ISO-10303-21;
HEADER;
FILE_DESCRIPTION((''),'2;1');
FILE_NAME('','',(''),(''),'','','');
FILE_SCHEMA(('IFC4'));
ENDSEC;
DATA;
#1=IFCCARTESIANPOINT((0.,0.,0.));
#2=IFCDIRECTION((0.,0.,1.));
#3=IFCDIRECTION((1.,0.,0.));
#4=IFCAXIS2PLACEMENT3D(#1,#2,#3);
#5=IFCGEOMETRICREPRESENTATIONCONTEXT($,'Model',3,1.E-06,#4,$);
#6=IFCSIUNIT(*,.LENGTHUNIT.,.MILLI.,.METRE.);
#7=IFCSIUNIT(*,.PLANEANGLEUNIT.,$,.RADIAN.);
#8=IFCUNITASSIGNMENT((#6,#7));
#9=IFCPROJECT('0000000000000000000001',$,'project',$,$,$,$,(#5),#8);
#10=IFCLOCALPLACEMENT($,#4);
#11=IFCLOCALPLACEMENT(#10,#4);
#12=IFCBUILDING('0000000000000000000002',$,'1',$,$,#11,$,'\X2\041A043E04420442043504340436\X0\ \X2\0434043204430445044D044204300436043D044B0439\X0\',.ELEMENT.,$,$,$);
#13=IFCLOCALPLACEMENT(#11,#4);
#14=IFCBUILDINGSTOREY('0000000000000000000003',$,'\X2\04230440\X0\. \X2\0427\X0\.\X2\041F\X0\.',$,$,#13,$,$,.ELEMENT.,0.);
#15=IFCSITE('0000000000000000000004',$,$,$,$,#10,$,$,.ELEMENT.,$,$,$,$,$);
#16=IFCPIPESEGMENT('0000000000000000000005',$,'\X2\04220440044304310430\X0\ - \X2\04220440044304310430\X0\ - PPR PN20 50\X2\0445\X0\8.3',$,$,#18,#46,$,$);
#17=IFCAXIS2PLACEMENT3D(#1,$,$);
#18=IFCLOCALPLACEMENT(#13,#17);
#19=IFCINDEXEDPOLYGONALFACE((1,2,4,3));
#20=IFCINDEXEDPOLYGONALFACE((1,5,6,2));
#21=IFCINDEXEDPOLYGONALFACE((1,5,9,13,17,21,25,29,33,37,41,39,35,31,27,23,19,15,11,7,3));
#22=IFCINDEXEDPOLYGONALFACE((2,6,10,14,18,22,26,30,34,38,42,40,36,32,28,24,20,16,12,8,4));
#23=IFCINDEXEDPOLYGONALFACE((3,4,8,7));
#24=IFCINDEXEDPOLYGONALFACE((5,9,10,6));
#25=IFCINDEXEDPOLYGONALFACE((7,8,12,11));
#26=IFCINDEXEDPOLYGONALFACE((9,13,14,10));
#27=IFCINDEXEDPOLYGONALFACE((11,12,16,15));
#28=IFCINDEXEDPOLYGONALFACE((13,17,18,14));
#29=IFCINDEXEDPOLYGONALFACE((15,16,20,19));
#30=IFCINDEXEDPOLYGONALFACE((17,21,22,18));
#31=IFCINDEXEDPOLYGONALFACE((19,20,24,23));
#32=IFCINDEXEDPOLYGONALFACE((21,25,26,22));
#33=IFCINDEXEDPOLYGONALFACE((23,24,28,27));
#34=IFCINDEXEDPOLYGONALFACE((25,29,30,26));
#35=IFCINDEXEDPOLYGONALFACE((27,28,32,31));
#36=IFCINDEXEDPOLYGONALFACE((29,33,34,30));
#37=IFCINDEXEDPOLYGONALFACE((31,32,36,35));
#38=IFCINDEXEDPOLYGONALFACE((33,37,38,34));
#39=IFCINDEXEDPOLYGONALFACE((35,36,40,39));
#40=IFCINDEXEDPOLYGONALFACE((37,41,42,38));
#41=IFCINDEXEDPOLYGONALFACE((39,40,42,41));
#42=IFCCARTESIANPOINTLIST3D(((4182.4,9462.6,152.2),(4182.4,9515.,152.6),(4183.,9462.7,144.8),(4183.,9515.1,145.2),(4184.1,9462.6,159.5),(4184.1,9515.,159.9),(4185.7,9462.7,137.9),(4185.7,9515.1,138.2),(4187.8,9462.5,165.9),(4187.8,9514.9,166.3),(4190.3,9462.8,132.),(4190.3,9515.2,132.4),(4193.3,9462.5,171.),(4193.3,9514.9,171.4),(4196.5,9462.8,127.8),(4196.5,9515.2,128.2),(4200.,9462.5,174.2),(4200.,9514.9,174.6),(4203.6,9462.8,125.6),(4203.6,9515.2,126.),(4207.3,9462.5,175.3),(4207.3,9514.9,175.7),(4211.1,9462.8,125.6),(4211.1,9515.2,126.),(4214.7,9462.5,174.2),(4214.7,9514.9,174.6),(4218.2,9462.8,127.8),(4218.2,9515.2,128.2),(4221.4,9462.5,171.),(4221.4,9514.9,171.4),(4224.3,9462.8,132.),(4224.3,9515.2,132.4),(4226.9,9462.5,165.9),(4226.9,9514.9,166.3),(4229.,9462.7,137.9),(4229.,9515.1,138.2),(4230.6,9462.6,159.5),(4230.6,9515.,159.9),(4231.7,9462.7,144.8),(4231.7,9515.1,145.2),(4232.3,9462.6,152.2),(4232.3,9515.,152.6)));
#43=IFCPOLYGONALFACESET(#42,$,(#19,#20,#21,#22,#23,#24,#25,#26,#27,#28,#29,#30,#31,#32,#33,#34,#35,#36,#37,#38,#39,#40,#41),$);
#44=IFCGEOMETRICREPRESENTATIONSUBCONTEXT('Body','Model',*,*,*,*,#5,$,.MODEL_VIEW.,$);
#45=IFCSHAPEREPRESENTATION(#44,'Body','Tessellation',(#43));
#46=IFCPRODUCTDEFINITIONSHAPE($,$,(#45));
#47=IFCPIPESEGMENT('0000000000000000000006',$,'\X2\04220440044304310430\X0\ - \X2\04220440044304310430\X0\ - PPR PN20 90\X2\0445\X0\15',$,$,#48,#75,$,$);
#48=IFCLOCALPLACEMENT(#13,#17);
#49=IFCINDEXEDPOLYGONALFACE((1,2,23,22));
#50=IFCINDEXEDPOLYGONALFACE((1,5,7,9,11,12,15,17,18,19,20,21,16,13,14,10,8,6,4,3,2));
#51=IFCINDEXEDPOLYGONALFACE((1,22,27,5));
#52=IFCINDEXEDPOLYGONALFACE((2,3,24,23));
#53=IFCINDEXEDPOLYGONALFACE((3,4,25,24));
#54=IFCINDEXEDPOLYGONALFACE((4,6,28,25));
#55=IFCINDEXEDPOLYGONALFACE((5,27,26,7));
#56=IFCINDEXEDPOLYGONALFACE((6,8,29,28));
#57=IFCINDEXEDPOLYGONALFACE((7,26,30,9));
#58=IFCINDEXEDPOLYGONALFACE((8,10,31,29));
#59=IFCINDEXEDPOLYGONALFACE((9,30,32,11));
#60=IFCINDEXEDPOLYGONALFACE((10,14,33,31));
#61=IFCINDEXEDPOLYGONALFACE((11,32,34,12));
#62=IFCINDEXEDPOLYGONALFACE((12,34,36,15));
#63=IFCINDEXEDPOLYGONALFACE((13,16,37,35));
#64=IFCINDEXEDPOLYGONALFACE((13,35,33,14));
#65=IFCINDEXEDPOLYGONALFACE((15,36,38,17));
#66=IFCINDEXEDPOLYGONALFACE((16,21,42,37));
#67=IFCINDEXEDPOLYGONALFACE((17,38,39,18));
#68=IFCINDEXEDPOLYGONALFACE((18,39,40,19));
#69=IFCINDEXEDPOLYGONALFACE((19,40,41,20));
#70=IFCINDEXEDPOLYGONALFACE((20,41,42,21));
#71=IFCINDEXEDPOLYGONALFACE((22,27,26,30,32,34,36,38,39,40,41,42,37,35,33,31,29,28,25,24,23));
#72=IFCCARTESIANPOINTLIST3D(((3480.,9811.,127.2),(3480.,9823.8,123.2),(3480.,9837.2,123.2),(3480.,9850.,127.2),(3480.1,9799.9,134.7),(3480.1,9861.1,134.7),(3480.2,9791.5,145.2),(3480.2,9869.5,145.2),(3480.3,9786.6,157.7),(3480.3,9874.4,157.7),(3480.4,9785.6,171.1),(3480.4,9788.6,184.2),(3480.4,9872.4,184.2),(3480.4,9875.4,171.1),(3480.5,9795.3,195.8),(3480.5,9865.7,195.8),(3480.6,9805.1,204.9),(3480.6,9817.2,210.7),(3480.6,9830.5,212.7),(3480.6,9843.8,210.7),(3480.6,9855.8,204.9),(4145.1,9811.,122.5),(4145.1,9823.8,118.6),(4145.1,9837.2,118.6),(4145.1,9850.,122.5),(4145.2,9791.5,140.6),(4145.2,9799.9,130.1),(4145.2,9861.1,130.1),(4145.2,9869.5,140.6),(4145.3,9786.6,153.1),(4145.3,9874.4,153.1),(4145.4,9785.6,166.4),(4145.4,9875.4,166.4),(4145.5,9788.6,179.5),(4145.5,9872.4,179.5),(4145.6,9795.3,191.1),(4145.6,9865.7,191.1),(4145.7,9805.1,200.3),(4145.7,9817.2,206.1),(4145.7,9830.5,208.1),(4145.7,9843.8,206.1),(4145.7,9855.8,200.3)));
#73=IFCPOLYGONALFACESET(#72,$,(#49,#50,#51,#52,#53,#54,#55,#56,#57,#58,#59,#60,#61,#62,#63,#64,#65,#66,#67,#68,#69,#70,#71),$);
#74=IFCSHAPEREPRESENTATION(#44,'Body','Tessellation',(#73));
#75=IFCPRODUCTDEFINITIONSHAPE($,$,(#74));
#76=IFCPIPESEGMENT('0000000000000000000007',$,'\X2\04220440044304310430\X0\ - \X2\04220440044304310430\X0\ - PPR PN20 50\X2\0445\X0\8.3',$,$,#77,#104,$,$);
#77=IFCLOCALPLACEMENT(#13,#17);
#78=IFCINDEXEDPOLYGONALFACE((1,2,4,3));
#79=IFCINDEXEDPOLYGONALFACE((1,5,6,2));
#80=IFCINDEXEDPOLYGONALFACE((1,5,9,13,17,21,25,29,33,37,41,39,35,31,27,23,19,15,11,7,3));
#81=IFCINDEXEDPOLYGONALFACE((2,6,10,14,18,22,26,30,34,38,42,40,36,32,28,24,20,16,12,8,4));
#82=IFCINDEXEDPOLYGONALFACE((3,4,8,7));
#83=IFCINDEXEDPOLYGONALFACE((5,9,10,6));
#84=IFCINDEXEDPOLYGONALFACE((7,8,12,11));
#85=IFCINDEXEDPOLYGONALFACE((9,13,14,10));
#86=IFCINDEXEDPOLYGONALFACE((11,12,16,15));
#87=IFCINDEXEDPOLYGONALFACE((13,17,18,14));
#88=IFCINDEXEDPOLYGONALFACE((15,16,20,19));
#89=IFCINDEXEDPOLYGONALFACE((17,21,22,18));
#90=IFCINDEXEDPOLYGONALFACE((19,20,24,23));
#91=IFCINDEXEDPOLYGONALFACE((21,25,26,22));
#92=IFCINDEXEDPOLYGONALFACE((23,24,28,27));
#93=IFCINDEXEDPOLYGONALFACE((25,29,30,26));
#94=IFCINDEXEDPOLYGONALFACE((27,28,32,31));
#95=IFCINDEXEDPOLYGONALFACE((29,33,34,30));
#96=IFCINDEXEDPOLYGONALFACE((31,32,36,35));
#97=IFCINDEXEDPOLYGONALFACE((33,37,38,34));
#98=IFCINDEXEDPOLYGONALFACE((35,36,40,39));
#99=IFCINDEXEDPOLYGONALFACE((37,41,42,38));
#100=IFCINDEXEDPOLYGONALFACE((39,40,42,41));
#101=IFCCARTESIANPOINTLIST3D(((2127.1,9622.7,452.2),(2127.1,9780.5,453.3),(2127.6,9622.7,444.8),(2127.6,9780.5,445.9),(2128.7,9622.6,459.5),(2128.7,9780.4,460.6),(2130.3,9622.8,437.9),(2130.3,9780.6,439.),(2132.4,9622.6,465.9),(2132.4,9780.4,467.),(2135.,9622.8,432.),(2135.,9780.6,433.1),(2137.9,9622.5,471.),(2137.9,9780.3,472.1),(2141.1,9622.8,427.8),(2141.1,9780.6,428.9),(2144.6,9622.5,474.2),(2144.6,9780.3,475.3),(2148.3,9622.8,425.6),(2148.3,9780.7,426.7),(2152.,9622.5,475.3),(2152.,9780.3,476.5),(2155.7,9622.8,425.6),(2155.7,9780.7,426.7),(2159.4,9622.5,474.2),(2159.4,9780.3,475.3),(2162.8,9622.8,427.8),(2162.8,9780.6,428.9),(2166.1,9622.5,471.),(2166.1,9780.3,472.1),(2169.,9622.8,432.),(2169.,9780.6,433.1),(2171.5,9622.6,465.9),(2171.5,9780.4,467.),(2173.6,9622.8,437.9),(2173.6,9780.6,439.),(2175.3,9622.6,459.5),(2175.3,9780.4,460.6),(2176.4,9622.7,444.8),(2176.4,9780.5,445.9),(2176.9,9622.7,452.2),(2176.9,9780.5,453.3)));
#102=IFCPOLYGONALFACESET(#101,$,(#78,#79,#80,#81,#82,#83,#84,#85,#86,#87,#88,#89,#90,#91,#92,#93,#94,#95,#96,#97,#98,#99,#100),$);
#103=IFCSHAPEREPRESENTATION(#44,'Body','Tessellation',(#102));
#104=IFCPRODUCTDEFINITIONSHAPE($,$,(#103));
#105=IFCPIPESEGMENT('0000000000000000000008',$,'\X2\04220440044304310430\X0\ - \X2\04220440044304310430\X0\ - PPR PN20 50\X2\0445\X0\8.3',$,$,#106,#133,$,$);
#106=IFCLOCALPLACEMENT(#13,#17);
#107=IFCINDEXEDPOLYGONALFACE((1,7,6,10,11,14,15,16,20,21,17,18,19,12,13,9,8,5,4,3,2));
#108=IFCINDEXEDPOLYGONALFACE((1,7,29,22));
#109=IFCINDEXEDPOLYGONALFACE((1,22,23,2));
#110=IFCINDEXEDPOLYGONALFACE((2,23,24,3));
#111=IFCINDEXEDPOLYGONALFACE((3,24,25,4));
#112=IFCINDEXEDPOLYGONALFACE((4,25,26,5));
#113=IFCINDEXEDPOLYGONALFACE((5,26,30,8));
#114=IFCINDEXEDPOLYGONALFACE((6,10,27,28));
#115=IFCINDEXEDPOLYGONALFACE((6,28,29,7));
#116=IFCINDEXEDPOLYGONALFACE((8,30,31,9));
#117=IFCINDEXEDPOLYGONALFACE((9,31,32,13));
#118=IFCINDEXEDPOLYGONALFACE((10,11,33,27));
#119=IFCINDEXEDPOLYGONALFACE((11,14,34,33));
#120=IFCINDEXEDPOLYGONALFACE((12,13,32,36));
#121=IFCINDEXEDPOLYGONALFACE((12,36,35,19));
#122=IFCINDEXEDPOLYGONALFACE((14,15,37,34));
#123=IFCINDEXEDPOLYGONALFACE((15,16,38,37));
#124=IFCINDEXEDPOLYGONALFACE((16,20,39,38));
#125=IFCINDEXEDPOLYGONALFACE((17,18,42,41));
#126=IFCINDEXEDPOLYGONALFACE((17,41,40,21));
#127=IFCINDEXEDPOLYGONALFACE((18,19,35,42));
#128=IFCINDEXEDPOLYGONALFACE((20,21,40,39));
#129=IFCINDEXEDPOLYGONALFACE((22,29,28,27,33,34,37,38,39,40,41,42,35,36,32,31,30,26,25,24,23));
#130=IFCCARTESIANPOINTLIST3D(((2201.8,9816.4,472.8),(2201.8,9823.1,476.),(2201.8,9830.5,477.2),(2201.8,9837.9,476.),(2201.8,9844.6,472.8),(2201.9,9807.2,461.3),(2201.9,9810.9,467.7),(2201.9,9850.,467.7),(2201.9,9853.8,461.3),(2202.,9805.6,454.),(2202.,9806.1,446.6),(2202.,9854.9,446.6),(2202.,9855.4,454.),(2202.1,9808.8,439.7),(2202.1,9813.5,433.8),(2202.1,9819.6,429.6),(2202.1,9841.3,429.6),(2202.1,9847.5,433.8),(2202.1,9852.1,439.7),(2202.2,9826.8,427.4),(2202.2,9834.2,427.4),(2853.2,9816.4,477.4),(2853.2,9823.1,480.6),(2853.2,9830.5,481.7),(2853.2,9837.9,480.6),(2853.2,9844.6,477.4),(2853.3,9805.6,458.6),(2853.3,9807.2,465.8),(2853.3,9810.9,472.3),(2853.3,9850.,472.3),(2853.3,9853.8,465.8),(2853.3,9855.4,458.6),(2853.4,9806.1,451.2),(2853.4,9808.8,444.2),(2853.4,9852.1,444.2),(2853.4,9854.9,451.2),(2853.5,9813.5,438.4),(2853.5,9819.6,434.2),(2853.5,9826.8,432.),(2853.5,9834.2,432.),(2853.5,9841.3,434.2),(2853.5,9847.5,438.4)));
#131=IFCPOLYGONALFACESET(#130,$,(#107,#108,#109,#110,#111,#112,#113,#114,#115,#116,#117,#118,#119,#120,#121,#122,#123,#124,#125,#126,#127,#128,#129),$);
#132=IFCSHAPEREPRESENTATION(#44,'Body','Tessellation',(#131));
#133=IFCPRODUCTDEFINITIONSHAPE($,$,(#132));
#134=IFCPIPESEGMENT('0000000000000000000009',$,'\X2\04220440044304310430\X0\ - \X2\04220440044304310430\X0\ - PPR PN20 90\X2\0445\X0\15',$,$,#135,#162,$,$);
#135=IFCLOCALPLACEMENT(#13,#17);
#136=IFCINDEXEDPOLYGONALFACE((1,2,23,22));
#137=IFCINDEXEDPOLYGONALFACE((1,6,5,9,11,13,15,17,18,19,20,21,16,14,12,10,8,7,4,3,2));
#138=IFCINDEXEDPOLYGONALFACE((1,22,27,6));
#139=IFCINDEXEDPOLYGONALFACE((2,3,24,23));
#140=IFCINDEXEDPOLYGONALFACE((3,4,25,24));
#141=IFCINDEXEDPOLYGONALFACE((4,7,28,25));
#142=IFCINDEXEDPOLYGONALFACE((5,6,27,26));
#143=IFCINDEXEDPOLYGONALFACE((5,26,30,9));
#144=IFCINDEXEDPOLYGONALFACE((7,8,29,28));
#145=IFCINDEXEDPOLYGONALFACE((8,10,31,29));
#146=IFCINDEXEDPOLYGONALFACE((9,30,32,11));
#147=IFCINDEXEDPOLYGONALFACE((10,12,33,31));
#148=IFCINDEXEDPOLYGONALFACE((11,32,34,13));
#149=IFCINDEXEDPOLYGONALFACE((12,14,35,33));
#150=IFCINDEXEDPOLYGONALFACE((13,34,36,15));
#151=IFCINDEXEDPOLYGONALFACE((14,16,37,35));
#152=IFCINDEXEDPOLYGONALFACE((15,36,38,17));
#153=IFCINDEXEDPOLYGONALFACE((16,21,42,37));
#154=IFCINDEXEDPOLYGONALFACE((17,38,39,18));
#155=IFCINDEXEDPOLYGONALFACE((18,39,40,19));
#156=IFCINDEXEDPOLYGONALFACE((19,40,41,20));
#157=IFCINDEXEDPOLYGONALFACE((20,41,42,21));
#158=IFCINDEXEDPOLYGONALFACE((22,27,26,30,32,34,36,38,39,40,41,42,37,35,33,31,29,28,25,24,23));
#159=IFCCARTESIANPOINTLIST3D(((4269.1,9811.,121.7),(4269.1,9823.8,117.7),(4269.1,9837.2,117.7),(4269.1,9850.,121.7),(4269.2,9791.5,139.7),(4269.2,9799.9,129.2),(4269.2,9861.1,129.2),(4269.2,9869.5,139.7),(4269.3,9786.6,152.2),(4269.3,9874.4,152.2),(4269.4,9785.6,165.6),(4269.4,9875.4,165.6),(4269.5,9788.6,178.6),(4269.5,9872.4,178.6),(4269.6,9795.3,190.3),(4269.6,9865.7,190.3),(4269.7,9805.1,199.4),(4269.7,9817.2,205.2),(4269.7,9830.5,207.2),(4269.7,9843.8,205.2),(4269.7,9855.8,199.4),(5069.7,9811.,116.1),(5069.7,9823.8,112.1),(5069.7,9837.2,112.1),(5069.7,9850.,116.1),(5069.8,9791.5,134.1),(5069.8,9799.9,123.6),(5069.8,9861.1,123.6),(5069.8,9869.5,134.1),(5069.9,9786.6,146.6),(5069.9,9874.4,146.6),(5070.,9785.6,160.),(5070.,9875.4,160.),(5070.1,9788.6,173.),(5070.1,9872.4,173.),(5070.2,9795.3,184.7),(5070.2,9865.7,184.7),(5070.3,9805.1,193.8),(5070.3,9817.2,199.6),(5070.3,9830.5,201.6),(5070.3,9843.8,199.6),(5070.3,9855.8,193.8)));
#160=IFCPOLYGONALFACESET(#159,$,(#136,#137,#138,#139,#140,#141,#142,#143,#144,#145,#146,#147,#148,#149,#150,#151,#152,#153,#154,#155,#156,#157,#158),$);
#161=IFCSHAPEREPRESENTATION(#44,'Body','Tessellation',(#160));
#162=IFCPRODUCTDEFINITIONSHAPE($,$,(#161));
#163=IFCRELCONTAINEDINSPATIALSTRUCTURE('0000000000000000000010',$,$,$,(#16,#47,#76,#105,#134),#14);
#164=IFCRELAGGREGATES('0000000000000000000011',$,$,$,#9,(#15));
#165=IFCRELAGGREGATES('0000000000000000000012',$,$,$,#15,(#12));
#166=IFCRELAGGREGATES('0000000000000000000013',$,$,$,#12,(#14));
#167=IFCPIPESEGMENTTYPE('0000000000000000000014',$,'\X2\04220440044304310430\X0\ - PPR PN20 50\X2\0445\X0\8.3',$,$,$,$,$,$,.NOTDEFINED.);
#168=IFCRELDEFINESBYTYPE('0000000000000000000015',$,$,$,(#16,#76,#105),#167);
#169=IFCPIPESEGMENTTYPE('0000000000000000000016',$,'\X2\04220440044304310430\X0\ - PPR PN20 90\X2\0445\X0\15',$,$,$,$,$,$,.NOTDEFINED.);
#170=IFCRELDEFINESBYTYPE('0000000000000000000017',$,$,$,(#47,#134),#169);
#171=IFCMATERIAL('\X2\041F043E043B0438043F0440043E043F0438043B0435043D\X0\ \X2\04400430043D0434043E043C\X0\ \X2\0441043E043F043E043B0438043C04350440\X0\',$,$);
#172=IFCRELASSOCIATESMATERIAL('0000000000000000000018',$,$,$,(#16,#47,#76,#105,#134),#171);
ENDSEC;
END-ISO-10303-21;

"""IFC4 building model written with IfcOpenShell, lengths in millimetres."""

from ifc_helpers import new_model, entity, si_unit, frame, origin_with_axes, place, context, subcontext, project, spatial, source, transform, mapped, material, type_object, element, save


model = new_model("IFC4")

# Units and contexts
model_context = context("Model", 3, precision=1e-06, world=origin_with_axes())
body_context = subcontext(model_context, "Body", "Model", "MODEL_VIEW")
ifc_project = project(units=[si_unit("LENGTHUNIT", "METRE", prefix="MILLI"), si_unit("PLANEANGLEUNIT", "RADIAN")], contexts=[model_context])

# Site, building, storey
site_placement = place(None, origin_with_axes())
site = spatial("IfcSite", under=ifc_project, at=site_placement, CompositionType="ELEMENT")
building_placement = place(site_placement, origin_with_axes())
building = spatial("IfcBuilding", under=site, at=building_placement, Name="1", LongName="Коттедж двухэтажный", CompositionType="ELEMENT")
storey_placement = place(building_placement, origin_with_axes())
storey = spatial("IfcBuildingStorey", under=building, at=storey_placement, Name="Ур. Ч.П.", CompositionType="ELEMENT", Elevation=0.0)

# Pipe segments
ifc_material_1 = material(Name="Полипропилен рандом сополимер")
pipe_segment_type_1 = type_object("IfcPipeSegmentType", Name="Труба - PPR PN20 50х8.3", PredefinedType="NOTDEFINED")
shared_shape_1 = source(origin_with_axes(), body_context, "Body", "AdvancedSweptSolid", [
    entity("IfcSweptDiskSolid", entity("IfcIndexedPolyCurve", entity("IfcCartesianPointList3D", [[0.0, 0.0, 0.0], [52.4, 0.0, 0.4]]), [entity("IfcLineIndex", [1, 2])]), 25.0),
])
pipe_segment_1_placement = place(storey_placement, frame((4207.3, 9462.6, 150.3), z_axis=(0.0, 0.0, 1.0), x_axis=(0.0, 1.0, 0.0)))
element("IfcPipeSegment", 1, at=pipe_segment_1_placement, inside=storey, type_object=pipe_segment_type_1, material=ifc_material_1, Name="Труба - Труба - PPR PN20 50х8.3", context=body_context, shape_type="MappedRepresentation", body=[
    mapped(shared_shape_1, transform((0.0, 0.0, 0.0), x_axis=(1.0, 0.0, 0.0), y_axis=(0.0, 1.0, 0.0), z_axis=(0.0, 0.0, 1.0), scale=1.0)),
])
pipe_segment_type_2 = type_object("IfcPipeSegmentType", Name="Труба - PPR PN20 90х15", PredefinedType="NOTDEFINED")
shared_shape_2 = source(origin_with_axes(), body_context, "Body", "AdvancedSweptSolid", [
    entity("IfcSweptDiskSolid", entity("IfcIndexedPolyCurve", entity("IfcCartesianPointList3D", [[0.0, 0.0, 0.0], [665.1, 0.0, 4.7]]), [entity("IfcLineIndex", [1, 2])]), 45.0),
])
pipe_segment_2_placement = place(storey_placement, frame((4145.4, 9830.5, 163.1), z_axis=(0.0, 0.0, 1.0), x_axis=(-1.0, 0.0, 0.0)))
element("IfcPipeSegment", 2, at=pipe_segment_2_placement, inside=storey, type_object=pipe_segment_type_2, material=ifc_material_1, Name="Труба - Труба - PPR PN20 90х15", context=body_context, shape_type="MappedRepresentation", body=[
    mapped(shared_shape_2, transform((0.0, 0.0, 0.0), x_axis=(1.0, 0.0, 0.0), y_axis=(0.0, 1.0, 0.0), z_axis=(0.0, 0.0, 1.0), scale=1.0)),
])
shared_shape_3 = source(origin_with_axes(), body_context, "Body", "AdvancedSweptSolid", [
    entity("IfcSweptDiskSolid", entity("IfcIndexedPolyCurve", entity("IfcCartesianPointList3D", [[0.0, 0.0, 0.0], [157.8, 0.0, 1.1]]), [entity("IfcLineIndex", [1, 2])]), 25.0),
])
pipe_segment_3_placement = place(storey_placement, frame((2152.0, 9622.7, 450.3), z_axis=(0.0, 0.0, 1.0), x_axis=(0.0, 1.0, 0.0)))
element("IfcPipeSegment", 3, at=pipe_segment_3_placement, inside=storey, type_object=pipe_segment_type_1, material=ifc_material_1, Name="Труба - Труба - PPR PN20 50х8.3", context=body_context, shape_type="MappedRepresentation", body=[
    mapped(shared_shape_3, transform((0.0, 0.0, 0.0), x_axis=(1.0, 0.0, 0.0), y_axis=(0.0, 1.0, 0.0), z_axis=(0.0, 0.0, 1.0), scale=1.0)),
])
shared_shape_4 = source(origin_with_axes(), body_context, "Body", "AdvancedSweptSolid", [
    entity("IfcSweptDiskSolid", entity("IfcIndexedPolyCurve", entity("IfcCartesianPointList3D", [[0.0, 0.0, 0.0], [651.4, 0.0, 4.6]]), [entity("IfcLineIndex", [1, 2])]), 25.0),
])
pipe_segment_4_placement = place(storey_placement, frame((2202.0, 9830.5, 452.2), z_axis=(0.0, 0.0, 1.0), x_axis=(1.0, 0.0, 0.0)))
element("IfcPipeSegment", 4, at=pipe_segment_4_placement, inside=storey, type_object=pipe_segment_type_1, material=ifc_material_1, Name="Труба - Труба - PPR PN20 50х8.3", context=body_context, shape_type="MappedRepresentation", body=[
    mapped(shared_shape_4, transform((0.0, 0.0, 0.0), x_axis=(1.0, 0.0, 0.0), y_axis=(0.0, 1.0, 0.0), z_axis=(0.0, 0.0, 1.0), scale=1.0)),
])
shared_shape_5 = source(origin_with_axes(), body_context, "Body", "AdvancedSweptSolid", [
    entity("IfcSweptDiskSolid", entity("IfcIndexedPolyCurve", entity("IfcCartesianPointList3D", [[0.0, 0.0, 0.0], [800.6, 0.0, 5.6]]), [entity("IfcLineIndex", [1, 2])]), 45.0),
])
pipe_segment_5_placement = place(storey_placement, frame((5070.0, 9830.5, 156.6), z_axis=(0.0, 0.0, 1.0), x_axis=(-1.0, 0.0, 0.0)))
element("IfcPipeSegment", 5, at=pipe_segment_5_placement, inside=storey, type_object=pipe_segment_type_2, material=ifc_material_1, Name="Труба - Труба - PPR PN20 90х15", context=body_context, shape_type="MappedRepresentation", body=[
    mapped(shared_shape_5, transform((0.0, 0.0, 0.0), x_axis=(1.0, 0.0, 0.0), y_axis=(0.0, 1.0, 0.0), z_axis=(0.0, 0.0, 1.0), scale=1.0)),
])

save(model, "model.ifc")
